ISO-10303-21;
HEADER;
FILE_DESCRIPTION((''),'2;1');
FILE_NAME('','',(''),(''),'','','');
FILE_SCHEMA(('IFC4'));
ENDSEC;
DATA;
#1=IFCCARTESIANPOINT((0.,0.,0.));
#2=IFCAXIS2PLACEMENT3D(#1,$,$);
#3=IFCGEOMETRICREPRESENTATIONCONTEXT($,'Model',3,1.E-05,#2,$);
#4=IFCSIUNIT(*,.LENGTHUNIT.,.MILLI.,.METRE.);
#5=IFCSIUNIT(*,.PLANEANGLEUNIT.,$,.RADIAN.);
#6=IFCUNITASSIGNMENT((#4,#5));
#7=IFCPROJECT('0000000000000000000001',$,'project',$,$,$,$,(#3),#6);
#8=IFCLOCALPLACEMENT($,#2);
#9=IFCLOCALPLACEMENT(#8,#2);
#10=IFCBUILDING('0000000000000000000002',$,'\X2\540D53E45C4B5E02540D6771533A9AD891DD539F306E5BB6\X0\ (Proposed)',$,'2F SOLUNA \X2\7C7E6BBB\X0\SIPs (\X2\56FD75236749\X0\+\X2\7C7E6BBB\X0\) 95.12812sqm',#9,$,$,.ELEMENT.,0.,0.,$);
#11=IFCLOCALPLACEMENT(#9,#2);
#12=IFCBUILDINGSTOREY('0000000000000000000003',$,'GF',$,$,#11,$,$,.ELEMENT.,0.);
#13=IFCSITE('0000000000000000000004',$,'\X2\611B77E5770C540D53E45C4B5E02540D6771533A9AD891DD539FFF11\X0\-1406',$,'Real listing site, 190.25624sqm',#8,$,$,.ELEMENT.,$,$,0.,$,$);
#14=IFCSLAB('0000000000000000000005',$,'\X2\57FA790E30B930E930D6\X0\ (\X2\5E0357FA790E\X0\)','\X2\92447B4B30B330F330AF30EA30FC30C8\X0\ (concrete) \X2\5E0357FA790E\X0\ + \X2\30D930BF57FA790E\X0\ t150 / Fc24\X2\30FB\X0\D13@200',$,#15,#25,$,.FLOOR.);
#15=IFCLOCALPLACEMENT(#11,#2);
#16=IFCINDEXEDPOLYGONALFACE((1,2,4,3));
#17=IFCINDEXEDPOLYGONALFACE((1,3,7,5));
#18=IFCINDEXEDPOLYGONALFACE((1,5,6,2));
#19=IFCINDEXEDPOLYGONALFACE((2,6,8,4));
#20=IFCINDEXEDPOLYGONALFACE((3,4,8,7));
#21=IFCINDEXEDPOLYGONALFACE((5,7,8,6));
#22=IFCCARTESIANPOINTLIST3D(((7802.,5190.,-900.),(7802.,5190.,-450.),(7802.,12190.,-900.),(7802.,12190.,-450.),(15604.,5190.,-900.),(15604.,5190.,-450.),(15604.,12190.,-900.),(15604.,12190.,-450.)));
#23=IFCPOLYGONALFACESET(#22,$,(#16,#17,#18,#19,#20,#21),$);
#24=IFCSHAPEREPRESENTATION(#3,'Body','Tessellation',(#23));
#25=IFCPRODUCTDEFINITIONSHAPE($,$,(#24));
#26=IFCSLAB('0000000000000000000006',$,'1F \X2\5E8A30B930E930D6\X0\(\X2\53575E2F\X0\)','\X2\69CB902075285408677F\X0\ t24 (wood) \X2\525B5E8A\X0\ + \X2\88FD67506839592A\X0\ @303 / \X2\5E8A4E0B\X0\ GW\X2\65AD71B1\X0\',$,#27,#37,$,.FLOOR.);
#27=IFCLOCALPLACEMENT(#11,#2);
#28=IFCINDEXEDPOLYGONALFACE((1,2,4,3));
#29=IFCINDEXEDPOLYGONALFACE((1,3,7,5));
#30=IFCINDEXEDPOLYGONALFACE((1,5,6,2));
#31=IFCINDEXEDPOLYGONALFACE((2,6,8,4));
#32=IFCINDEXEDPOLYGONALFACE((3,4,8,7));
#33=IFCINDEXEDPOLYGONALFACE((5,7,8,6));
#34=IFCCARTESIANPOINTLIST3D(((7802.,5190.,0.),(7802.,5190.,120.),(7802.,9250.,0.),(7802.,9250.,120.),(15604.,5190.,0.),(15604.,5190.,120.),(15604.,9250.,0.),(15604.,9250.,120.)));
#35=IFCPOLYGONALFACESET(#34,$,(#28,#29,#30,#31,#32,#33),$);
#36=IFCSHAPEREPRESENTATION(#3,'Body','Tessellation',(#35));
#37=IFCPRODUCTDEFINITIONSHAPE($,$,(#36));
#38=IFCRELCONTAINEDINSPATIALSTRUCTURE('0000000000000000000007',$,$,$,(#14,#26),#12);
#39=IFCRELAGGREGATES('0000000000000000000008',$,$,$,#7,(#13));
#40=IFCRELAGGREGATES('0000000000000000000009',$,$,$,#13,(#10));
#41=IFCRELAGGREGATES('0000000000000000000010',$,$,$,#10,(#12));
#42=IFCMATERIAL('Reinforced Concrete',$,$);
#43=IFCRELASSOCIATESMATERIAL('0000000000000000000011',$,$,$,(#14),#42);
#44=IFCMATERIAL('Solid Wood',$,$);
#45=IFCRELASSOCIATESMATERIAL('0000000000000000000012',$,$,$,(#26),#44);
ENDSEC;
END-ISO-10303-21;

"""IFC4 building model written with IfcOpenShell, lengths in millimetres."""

from ifc_helpers import new_model, si_unit, frame, frame_2d, origin, place, context, project, spatial, rectangle, extrude, material, element, save


model = new_model("IFC4")

# Units and contexts
model_context = context("Model", 3, precision=1e-05, world=origin())
ifc_project = project(units=[si_unit("LENGTHUNIT", "METRE", prefix="MILLI"), si_unit("PLANEANGLEUNIT", "RADIAN")], contexts=[model_context])

# Site, building, storey
site_placement = place(None, origin())
site = spatial("IfcSite", under=ifc_project, at=site_placement, Name="愛知県名古屋市名東区高針原１-1406", ObjectType="Real listing site, 190.25624sqm", CompositionType="ELEMENT", RefElevation=0.0)
building_placement = place(site_placement, origin())
building = spatial("IfcBuilding", under=site, at=building_placement, Name="名古屋市名東区高針原の家 (Proposed)", ObjectType="2F SOLUNA 籾殻SIPs (国産杉+籾殻) 95.12812sqm", CompositionType="ELEMENT", ElevationOfRefHeight=0.0, ElevationOfTerrain=0.0)
storey_placement = place(building_placement, origin())
storey = spatial("IfcBuildingStorey", under=building, at=storey_placement, Name="GF", CompositionType="ELEMENT", Elevation=0.0)

# Slabs
ifc_material_1 = material(Name="Reinforced Concrete")
slab_1_placement = place(storey_placement, frame((3901.0, 2595.0, -450.0)))
element("IfcSlab", 1, at=slab_1_placement, inside=storey, material=ifc_material_1, Name="基礎スラブ (布基礎)", Description="鉄筋コンクリート (concrete) 布基礎 + ベタ基礎 t150 / Fc24・D13@200", PredefinedType="FLOOR", context=model_context, shape_type="SweptSolid", body=[
    extrude(rectangle(XDim=7802.0, YDim=7000.0, at=frame_2d((3901.0, 3500.0))), frame((3901.0, 2595.0, -450.0)), (0.0, 0.0, 1.0), 450.0),
])
ifc_material_2 = material(Name="Solid Wood")
slab_2_placement = place(storey_placement, frame((3901.0, 2595.0, 0.0)))
element("IfcSlab", 2, at=slab_2_placement, inside=storey, material=ifc_material_2, Name="1F 床スラブ(南帯)", Description="構造用合板 t24 (wood) 剛床 + 製材根太 @303 / 床下 GW断熱", PredefinedType="FLOOR", context=model_context, shape_type="SweptSolid", body=[
    extrude(rectangle(XDim=7802.0, YDim=4060.0, at=frame_2d((3901.0, 2030.0))), frame((3901.0, 2595.0, 0.0)), (0.0, 0.0, 1.0), 120.0),
])

save(model, "model.ifc")
